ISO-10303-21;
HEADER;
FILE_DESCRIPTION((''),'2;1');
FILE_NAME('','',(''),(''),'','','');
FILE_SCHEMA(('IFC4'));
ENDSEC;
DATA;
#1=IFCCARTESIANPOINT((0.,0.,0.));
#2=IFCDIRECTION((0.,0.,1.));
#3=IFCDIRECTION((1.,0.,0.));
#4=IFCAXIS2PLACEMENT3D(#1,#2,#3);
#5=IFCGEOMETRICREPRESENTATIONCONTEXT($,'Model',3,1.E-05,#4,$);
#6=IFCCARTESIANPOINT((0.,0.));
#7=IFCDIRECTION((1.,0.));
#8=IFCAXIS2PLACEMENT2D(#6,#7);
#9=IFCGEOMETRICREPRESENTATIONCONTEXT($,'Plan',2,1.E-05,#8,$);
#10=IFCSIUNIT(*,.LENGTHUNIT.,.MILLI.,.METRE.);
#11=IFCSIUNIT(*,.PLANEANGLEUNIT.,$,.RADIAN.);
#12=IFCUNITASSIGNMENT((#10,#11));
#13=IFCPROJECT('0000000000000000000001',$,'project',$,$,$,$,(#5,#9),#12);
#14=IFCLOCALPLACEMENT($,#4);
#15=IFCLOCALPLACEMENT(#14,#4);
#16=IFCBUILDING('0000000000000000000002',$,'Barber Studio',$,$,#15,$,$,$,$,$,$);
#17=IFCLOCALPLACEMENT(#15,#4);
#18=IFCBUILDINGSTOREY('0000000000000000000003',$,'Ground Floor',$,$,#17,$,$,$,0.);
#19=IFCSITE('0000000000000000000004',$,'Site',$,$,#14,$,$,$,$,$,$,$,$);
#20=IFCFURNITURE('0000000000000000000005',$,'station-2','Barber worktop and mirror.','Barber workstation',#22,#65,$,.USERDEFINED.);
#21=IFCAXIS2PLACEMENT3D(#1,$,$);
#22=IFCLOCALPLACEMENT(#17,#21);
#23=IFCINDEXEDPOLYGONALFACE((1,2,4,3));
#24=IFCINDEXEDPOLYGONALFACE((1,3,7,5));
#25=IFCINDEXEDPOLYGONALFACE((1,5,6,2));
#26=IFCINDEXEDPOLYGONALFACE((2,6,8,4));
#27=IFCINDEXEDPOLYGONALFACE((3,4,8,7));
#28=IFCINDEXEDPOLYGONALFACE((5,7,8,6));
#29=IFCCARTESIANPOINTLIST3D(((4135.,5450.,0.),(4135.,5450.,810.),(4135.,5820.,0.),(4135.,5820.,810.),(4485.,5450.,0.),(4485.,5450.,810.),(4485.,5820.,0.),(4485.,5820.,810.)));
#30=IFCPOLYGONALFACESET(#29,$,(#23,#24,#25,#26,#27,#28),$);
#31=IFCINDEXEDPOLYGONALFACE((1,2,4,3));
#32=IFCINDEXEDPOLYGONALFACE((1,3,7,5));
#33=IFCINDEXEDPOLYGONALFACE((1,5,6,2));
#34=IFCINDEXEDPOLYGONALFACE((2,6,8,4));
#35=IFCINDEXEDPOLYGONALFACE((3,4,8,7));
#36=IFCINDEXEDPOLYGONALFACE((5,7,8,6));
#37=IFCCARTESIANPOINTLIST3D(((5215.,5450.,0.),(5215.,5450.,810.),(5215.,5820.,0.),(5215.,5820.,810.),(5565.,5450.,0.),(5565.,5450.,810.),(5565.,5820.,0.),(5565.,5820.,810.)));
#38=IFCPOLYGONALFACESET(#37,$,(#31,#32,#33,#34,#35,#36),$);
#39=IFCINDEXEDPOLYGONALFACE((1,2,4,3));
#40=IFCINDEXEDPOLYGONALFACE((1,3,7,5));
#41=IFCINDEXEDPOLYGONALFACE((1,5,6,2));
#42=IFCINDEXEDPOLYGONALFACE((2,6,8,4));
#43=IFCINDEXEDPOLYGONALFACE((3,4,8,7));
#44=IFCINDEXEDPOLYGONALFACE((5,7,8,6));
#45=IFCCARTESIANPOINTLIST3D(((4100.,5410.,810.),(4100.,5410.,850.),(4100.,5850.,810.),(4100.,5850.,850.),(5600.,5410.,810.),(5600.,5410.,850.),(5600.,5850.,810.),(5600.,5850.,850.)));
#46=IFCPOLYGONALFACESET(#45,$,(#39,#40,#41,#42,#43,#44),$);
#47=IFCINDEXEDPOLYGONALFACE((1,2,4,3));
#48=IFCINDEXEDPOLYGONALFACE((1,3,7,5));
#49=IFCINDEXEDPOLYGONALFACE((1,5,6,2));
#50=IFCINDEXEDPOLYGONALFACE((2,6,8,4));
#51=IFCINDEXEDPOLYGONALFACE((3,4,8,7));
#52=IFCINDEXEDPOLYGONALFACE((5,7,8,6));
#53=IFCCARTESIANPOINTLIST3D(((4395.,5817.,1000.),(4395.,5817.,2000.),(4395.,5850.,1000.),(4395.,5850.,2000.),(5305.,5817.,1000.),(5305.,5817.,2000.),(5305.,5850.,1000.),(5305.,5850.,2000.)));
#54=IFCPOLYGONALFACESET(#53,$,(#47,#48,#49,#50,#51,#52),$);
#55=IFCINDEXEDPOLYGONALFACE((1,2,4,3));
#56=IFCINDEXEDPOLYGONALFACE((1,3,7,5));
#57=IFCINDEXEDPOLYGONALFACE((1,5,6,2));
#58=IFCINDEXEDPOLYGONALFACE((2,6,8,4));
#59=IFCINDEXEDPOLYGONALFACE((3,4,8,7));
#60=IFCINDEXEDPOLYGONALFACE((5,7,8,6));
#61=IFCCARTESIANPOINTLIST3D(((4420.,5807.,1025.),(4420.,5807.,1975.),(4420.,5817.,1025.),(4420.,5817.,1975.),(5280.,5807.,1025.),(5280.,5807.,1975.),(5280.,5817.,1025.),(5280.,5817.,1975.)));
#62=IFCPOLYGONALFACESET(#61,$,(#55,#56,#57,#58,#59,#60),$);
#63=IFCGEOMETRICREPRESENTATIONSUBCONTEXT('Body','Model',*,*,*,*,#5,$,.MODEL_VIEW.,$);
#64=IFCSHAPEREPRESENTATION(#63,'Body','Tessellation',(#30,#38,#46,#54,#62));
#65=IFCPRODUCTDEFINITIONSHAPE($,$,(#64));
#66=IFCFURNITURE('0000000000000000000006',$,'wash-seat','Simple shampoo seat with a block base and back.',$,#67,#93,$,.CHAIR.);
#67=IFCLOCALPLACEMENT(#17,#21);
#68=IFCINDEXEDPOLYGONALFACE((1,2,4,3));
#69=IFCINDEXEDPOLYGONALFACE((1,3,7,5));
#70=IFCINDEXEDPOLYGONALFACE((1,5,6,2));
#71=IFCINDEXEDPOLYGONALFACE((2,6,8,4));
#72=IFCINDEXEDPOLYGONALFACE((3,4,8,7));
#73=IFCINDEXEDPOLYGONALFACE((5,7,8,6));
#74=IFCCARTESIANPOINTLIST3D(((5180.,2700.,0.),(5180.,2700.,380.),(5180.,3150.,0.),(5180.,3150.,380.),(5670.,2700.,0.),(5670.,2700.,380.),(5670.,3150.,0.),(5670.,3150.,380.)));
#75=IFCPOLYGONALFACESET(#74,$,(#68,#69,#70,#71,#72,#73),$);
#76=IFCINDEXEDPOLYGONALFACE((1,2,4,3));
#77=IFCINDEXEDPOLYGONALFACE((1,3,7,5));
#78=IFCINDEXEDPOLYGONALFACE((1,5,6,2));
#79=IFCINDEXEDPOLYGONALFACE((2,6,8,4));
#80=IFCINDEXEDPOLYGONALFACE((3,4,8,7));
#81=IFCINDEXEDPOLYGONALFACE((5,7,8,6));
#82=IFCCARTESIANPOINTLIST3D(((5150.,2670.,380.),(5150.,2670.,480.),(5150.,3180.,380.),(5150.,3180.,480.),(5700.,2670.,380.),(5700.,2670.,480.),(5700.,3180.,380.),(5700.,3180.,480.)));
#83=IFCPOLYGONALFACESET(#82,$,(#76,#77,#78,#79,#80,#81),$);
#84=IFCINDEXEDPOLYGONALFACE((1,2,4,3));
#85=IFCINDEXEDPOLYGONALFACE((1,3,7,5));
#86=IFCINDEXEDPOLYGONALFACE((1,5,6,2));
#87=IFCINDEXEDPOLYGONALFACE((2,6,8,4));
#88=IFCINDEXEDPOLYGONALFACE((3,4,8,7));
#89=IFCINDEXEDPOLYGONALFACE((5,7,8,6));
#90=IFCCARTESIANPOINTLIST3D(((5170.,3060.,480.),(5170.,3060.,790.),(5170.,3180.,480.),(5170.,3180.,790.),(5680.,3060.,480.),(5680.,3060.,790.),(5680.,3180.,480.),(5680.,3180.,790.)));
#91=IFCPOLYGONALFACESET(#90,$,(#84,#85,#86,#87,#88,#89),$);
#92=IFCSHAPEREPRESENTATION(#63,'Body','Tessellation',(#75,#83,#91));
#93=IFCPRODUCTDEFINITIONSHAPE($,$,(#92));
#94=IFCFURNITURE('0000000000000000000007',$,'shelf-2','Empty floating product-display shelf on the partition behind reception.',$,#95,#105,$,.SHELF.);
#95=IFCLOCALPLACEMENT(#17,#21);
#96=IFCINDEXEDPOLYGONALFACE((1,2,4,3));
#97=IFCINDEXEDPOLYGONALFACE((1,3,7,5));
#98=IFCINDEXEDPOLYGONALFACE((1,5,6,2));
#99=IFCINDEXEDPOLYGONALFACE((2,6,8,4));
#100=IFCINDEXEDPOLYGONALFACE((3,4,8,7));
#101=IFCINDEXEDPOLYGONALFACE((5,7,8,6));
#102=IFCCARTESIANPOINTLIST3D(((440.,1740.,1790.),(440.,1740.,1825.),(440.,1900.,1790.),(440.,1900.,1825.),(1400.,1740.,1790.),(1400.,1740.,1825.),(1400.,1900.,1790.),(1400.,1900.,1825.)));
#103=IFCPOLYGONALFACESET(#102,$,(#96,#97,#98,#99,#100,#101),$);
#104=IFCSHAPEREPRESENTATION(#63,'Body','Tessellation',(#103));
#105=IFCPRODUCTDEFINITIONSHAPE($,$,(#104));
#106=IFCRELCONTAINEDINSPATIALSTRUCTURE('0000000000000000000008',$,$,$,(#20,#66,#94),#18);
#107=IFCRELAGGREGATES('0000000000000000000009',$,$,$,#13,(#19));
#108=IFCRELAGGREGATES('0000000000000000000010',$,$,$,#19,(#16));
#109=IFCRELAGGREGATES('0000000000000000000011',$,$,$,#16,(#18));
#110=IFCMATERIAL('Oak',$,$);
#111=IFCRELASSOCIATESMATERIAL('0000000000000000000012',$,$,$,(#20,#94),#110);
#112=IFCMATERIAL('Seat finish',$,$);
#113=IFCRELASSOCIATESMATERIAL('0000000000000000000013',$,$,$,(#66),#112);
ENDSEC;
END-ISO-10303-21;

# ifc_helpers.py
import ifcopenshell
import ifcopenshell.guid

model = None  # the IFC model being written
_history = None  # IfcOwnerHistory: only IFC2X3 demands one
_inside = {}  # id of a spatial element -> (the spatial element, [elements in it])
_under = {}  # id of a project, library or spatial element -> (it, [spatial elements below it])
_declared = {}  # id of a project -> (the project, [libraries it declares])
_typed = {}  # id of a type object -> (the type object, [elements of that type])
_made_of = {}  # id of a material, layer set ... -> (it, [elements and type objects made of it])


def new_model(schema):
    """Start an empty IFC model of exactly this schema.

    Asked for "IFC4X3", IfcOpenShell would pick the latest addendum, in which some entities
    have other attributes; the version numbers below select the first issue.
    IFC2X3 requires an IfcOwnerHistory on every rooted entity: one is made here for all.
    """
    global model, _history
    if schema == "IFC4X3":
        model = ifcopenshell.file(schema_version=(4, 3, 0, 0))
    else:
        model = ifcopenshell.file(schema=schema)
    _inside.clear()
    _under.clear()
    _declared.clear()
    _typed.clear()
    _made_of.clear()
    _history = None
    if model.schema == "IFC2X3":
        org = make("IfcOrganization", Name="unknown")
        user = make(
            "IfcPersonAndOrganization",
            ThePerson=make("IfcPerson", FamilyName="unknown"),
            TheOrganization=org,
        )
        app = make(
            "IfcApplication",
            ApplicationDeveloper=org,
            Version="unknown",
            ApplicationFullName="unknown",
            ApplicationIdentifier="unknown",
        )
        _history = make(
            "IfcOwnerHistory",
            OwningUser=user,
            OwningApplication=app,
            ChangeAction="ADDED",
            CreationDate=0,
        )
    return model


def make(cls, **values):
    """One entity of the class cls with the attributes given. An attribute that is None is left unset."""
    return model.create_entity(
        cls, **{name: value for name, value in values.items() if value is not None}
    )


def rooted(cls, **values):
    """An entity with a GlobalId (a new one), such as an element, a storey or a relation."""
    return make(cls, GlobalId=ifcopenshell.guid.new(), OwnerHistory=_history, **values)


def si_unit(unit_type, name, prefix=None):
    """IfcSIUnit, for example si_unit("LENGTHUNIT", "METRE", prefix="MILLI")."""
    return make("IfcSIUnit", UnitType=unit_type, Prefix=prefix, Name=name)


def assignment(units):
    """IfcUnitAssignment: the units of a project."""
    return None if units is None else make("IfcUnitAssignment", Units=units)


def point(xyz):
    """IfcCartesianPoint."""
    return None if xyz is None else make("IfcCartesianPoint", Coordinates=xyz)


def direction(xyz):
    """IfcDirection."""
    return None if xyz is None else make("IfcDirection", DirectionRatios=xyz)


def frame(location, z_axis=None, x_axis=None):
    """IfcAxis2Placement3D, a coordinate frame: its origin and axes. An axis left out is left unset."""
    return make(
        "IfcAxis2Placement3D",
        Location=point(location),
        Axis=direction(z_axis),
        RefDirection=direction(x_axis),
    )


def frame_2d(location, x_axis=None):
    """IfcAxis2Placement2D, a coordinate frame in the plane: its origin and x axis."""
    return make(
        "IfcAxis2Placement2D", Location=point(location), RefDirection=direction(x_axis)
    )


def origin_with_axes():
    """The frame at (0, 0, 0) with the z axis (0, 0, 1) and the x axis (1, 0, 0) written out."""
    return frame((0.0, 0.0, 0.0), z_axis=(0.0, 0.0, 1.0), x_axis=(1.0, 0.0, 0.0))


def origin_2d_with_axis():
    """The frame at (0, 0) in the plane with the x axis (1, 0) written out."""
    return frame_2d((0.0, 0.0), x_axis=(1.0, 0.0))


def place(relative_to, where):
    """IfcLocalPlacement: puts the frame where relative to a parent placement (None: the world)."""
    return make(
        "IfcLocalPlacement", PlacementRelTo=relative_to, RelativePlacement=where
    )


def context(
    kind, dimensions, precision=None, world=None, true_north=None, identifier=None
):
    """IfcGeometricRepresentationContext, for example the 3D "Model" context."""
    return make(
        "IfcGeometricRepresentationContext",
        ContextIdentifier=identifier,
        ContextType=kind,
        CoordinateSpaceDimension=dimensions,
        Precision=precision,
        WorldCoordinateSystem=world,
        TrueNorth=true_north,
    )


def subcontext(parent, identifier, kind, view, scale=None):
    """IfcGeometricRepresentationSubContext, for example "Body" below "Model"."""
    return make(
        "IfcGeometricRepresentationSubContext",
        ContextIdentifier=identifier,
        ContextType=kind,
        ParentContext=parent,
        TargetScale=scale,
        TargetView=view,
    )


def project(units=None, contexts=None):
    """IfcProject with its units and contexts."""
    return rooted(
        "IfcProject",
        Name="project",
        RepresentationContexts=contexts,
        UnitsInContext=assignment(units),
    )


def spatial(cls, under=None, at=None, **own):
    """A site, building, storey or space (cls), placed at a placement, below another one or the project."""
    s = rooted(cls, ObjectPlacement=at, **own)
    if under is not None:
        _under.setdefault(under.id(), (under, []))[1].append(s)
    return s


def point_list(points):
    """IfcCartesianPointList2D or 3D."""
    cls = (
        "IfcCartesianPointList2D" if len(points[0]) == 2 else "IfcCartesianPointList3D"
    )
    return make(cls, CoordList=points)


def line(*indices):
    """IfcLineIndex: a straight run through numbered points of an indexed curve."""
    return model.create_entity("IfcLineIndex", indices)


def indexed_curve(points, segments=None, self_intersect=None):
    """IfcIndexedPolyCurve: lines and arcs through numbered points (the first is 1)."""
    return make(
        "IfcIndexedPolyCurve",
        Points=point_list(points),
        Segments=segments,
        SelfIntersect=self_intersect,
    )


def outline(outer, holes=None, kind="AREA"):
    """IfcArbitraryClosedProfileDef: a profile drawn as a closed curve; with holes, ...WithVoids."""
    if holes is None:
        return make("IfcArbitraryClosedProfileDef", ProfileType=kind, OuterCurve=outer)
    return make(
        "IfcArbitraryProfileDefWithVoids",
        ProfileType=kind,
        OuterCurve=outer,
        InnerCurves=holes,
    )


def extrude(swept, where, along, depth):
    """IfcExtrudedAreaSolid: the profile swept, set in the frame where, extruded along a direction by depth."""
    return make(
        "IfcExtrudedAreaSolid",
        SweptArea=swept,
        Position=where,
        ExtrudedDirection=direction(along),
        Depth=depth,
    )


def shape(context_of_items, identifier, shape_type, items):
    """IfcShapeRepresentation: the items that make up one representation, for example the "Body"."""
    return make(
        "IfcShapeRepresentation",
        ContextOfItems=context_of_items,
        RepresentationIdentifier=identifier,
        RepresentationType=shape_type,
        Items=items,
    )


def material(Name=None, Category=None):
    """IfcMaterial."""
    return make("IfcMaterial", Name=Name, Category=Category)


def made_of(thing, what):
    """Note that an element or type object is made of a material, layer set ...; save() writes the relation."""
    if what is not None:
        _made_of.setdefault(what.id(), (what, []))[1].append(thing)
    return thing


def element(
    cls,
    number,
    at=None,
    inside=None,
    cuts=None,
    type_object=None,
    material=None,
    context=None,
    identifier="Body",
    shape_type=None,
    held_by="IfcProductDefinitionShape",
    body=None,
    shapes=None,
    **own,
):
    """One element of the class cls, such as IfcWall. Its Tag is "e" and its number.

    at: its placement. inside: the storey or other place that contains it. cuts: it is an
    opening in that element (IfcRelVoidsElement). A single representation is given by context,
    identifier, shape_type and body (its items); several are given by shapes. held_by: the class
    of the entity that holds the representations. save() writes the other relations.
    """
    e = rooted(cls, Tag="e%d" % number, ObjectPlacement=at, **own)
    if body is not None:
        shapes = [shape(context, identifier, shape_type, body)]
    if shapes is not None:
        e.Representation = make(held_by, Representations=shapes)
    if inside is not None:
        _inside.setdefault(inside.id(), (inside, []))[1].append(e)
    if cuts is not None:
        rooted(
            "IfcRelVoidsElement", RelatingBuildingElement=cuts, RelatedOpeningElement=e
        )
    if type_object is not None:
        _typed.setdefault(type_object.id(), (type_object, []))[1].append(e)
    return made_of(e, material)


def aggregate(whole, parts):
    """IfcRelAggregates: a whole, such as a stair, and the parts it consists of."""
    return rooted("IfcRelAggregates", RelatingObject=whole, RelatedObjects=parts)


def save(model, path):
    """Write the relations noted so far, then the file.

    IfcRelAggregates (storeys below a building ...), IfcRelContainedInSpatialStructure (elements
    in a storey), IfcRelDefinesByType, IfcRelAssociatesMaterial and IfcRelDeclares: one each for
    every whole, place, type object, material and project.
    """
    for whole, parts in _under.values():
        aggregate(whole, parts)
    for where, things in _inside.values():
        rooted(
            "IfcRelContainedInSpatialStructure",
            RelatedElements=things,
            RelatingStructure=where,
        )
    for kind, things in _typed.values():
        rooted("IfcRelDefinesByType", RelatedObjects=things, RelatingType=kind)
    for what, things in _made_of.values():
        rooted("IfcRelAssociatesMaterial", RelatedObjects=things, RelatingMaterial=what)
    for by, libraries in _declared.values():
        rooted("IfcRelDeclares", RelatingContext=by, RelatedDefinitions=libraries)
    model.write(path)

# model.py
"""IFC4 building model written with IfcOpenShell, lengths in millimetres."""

from ifc_helpers import new_model, si_unit, frame, origin_with_axes, origin_2d_with_axis, place, context, subcontext, project, spatial, line, indexed_curve, outline, extrude, material, element, save


model = new_model("IFC4")

# Units and contexts
model_context = context("Model", 3, precision=1e-05, world=origin_with_axes())
plan_context = context("Plan", 2, precision=1e-05, world=origin_2d_with_axis())
body_context_1 = subcontext(model_context, "Body", "Model", "MODEL_VIEW")
ifc_project = project(units=[si_unit("LENGTHUNIT", "METRE", prefix="MILLI"), si_unit("PLANEANGLEUNIT", "RADIAN")], contexts=[model_context, plan_context])

# Site, building, storey
site_placement = place(None, origin_with_axes())
site = spatial("IfcSite", under=ifc_project, at=site_placement, Name="Site")
building_placement = place(site_placement, origin_with_axes())
building = spatial("IfcBuilding", under=site, at=building_placement, Name="Barber Studio")
storey_placement = place(building_placement, origin_with_axes())
storey = spatial("IfcBuildingStorey", under=building, at=storey_placement, Name="Ground Floor", Elevation=0.0)

# Furniture
ifc_material_1 = material(Name="Seat finish")
ifc_material_2 = material(Name="Oak")
for number, where, z_axis, x_axis, name in (
    (1, (4100.0, 5410.0, 0.0), (0.0, 0.0, 1.0), (1.0, 0.0, 0.0), "station-2"),
):
    element("IfcFurniture", number, at=place(storey_placement, frame(where, z_axis=z_axis, x_axis=x_axis)), inside=storey, material=ifc_material_2, Name=name, Description="Barber worktop and mirror.", ObjectType="Barber workstation", PredefinedType="USERDEFINED", context=body_context_1, shape_type="SweptSolid", body=[
        extrude(outline(indexed_curve([(0.0, 0.0), (350.0, 0.0), (350.0, 370.0), (0.0, 370.0)], segments=[line(1, 2, 3, 4, 1)])), frame((35.0, 40.0, 0.0), z_axis=(0.0, 0.0, 1.0), x_axis=(1.0, 0.0, 0.0)), (0.0, 0.0, 1.0), 810.0),
        extrude(outline(indexed_curve([(0.0, 0.0), (350.0, 0.0), (350.0, 370.0), (0.0, 370.0)], segments=[line(1, 2, 3, 4, 1)])), frame((1115.0, 40.0, 0.0), z_axis=(0.0, 0.0, 1.0), x_axis=(1.0, 0.0, 0.0)), (0.0, 0.0, 1.0), 810.0),
        extrude(outline(indexed_curve([(0.0, 0.0), (1500.0, 0.0), (1500.0, 440.0), (0.0, 440.0)], segments=[line(1, 2, 3, 4, 1)])), frame((0.0, 0.0, 810.0), z_axis=(0.0, 0.0, 1.0), x_axis=(1.0, 0.0, 0.0)), (0.0, 0.0, 1.0), 40.0),
        extrude(outline(indexed_curve([(0.0, 0.0), (910.0, 0.0), (910.0, 33.0), (0.0, 33.0)], segments=[line(1, 2, 3, 4, 1)])), frame((295.0, 407.0, 1000.0), z_axis=(0.0, 0.0, 1.0), x_axis=(1.0, 0.0, 0.0)), (0.0, 0.0, 1.0), 1000.0),
        extrude(outline(indexed_curve([(0.0, 0.0), (860.0, 0.0), (860.0, 10.0), (0.0, 10.0)], segments=[line(1, 2, 3, 4, 1)])), frame((320.0, 397.0, 1025.0), z_axis=(0.0, 0.0, 1.0), x_axis=(1.0, 0.0, 0.0)), (0.0, 0.0, 1.0), 950.0),
    ])
furniture_1_placement = place(storey_placement, frame((5150.0, 2670.0, 0.0), z_axis=(0.0, 0.0, 1.0), x_axis=(1.0, 0.0, 0.0)))
element("IfcFurniture", 2, at=furniture_1_placement, inside=storey, material=ifc_material_1, Name="wash-seat", Description="Simple shampoo seat with a block base and back.", PredefinedType="CHAIR", context=body_context_1, shape_type="SweptSolid", body=[
    extrude(outline(indexed_curve([(0.0, 0.0), (490.0, 0.0), (490.0, 450.0), (0.0, 450.0)], segments=[line(1, 2, 3, 4, 1)])), frame((30.0, 30.0, 0.0), z_axis=(0.0, 0.0, 1.0), x_axis=(1.0, 0.0, 0.0)), (0.0, 0.0, 1.0), 380.0),
    extrude(outline(indexed_curve([(0.0, 0.0), (550.0, 0.0), (550.0, 510.0), (0.0, 510.0)], segments=[line(1, 2, 3, 4, 1)])), frame((0.0, 0.0, 380.0), z_axis=(0.0, 0.0, 1.0), x_axis=(1.0, 0.0, 0.0)), (0.0, 0.0, 1.0), 100.0),
    extrude(outline(indexed_curve([(0.0, 0.0), (510.0, 0.0), (510.0, 120.0), (0.0, 120.0)], segments=[line(1, 2, 3, 4, 1)])), frame((20.0, 390.0, 480.0), z_axis=(0.0, 0.0, 1.0), x_axis=(1.0, 0.0, 0.0)), (0.0, 0.0, 1.0), 310.0),
])
furniture_2_placement = place(storey_placement, frame((440.0, 1740.0, 1790.0), z_axis=(0.0, 0.0, 1.0), x_axis=(1.0, 0.0, 0.0)))
element("IfcFurniture", 3, at=furniture_2_placement, inside=storey, material=ifc_material_2, Name="shelf-2", Description="Empty floating product-display shelf on the partition behind reception.", PredefinedType="SHELF", context=body_context_1, shape_type="SweptSolid", body=[
    extrude(outline(indexed_curve([(0.0, 0.0), (960.0, 0.0), (960.0, 160.0), (0.0, 160.0)], segments=[line(1, 2, 3, 4, 1)])), origin_with_axes(), (0.0, 0.0, 1.0), 35.0),
])

save(model, "model.ifc")
